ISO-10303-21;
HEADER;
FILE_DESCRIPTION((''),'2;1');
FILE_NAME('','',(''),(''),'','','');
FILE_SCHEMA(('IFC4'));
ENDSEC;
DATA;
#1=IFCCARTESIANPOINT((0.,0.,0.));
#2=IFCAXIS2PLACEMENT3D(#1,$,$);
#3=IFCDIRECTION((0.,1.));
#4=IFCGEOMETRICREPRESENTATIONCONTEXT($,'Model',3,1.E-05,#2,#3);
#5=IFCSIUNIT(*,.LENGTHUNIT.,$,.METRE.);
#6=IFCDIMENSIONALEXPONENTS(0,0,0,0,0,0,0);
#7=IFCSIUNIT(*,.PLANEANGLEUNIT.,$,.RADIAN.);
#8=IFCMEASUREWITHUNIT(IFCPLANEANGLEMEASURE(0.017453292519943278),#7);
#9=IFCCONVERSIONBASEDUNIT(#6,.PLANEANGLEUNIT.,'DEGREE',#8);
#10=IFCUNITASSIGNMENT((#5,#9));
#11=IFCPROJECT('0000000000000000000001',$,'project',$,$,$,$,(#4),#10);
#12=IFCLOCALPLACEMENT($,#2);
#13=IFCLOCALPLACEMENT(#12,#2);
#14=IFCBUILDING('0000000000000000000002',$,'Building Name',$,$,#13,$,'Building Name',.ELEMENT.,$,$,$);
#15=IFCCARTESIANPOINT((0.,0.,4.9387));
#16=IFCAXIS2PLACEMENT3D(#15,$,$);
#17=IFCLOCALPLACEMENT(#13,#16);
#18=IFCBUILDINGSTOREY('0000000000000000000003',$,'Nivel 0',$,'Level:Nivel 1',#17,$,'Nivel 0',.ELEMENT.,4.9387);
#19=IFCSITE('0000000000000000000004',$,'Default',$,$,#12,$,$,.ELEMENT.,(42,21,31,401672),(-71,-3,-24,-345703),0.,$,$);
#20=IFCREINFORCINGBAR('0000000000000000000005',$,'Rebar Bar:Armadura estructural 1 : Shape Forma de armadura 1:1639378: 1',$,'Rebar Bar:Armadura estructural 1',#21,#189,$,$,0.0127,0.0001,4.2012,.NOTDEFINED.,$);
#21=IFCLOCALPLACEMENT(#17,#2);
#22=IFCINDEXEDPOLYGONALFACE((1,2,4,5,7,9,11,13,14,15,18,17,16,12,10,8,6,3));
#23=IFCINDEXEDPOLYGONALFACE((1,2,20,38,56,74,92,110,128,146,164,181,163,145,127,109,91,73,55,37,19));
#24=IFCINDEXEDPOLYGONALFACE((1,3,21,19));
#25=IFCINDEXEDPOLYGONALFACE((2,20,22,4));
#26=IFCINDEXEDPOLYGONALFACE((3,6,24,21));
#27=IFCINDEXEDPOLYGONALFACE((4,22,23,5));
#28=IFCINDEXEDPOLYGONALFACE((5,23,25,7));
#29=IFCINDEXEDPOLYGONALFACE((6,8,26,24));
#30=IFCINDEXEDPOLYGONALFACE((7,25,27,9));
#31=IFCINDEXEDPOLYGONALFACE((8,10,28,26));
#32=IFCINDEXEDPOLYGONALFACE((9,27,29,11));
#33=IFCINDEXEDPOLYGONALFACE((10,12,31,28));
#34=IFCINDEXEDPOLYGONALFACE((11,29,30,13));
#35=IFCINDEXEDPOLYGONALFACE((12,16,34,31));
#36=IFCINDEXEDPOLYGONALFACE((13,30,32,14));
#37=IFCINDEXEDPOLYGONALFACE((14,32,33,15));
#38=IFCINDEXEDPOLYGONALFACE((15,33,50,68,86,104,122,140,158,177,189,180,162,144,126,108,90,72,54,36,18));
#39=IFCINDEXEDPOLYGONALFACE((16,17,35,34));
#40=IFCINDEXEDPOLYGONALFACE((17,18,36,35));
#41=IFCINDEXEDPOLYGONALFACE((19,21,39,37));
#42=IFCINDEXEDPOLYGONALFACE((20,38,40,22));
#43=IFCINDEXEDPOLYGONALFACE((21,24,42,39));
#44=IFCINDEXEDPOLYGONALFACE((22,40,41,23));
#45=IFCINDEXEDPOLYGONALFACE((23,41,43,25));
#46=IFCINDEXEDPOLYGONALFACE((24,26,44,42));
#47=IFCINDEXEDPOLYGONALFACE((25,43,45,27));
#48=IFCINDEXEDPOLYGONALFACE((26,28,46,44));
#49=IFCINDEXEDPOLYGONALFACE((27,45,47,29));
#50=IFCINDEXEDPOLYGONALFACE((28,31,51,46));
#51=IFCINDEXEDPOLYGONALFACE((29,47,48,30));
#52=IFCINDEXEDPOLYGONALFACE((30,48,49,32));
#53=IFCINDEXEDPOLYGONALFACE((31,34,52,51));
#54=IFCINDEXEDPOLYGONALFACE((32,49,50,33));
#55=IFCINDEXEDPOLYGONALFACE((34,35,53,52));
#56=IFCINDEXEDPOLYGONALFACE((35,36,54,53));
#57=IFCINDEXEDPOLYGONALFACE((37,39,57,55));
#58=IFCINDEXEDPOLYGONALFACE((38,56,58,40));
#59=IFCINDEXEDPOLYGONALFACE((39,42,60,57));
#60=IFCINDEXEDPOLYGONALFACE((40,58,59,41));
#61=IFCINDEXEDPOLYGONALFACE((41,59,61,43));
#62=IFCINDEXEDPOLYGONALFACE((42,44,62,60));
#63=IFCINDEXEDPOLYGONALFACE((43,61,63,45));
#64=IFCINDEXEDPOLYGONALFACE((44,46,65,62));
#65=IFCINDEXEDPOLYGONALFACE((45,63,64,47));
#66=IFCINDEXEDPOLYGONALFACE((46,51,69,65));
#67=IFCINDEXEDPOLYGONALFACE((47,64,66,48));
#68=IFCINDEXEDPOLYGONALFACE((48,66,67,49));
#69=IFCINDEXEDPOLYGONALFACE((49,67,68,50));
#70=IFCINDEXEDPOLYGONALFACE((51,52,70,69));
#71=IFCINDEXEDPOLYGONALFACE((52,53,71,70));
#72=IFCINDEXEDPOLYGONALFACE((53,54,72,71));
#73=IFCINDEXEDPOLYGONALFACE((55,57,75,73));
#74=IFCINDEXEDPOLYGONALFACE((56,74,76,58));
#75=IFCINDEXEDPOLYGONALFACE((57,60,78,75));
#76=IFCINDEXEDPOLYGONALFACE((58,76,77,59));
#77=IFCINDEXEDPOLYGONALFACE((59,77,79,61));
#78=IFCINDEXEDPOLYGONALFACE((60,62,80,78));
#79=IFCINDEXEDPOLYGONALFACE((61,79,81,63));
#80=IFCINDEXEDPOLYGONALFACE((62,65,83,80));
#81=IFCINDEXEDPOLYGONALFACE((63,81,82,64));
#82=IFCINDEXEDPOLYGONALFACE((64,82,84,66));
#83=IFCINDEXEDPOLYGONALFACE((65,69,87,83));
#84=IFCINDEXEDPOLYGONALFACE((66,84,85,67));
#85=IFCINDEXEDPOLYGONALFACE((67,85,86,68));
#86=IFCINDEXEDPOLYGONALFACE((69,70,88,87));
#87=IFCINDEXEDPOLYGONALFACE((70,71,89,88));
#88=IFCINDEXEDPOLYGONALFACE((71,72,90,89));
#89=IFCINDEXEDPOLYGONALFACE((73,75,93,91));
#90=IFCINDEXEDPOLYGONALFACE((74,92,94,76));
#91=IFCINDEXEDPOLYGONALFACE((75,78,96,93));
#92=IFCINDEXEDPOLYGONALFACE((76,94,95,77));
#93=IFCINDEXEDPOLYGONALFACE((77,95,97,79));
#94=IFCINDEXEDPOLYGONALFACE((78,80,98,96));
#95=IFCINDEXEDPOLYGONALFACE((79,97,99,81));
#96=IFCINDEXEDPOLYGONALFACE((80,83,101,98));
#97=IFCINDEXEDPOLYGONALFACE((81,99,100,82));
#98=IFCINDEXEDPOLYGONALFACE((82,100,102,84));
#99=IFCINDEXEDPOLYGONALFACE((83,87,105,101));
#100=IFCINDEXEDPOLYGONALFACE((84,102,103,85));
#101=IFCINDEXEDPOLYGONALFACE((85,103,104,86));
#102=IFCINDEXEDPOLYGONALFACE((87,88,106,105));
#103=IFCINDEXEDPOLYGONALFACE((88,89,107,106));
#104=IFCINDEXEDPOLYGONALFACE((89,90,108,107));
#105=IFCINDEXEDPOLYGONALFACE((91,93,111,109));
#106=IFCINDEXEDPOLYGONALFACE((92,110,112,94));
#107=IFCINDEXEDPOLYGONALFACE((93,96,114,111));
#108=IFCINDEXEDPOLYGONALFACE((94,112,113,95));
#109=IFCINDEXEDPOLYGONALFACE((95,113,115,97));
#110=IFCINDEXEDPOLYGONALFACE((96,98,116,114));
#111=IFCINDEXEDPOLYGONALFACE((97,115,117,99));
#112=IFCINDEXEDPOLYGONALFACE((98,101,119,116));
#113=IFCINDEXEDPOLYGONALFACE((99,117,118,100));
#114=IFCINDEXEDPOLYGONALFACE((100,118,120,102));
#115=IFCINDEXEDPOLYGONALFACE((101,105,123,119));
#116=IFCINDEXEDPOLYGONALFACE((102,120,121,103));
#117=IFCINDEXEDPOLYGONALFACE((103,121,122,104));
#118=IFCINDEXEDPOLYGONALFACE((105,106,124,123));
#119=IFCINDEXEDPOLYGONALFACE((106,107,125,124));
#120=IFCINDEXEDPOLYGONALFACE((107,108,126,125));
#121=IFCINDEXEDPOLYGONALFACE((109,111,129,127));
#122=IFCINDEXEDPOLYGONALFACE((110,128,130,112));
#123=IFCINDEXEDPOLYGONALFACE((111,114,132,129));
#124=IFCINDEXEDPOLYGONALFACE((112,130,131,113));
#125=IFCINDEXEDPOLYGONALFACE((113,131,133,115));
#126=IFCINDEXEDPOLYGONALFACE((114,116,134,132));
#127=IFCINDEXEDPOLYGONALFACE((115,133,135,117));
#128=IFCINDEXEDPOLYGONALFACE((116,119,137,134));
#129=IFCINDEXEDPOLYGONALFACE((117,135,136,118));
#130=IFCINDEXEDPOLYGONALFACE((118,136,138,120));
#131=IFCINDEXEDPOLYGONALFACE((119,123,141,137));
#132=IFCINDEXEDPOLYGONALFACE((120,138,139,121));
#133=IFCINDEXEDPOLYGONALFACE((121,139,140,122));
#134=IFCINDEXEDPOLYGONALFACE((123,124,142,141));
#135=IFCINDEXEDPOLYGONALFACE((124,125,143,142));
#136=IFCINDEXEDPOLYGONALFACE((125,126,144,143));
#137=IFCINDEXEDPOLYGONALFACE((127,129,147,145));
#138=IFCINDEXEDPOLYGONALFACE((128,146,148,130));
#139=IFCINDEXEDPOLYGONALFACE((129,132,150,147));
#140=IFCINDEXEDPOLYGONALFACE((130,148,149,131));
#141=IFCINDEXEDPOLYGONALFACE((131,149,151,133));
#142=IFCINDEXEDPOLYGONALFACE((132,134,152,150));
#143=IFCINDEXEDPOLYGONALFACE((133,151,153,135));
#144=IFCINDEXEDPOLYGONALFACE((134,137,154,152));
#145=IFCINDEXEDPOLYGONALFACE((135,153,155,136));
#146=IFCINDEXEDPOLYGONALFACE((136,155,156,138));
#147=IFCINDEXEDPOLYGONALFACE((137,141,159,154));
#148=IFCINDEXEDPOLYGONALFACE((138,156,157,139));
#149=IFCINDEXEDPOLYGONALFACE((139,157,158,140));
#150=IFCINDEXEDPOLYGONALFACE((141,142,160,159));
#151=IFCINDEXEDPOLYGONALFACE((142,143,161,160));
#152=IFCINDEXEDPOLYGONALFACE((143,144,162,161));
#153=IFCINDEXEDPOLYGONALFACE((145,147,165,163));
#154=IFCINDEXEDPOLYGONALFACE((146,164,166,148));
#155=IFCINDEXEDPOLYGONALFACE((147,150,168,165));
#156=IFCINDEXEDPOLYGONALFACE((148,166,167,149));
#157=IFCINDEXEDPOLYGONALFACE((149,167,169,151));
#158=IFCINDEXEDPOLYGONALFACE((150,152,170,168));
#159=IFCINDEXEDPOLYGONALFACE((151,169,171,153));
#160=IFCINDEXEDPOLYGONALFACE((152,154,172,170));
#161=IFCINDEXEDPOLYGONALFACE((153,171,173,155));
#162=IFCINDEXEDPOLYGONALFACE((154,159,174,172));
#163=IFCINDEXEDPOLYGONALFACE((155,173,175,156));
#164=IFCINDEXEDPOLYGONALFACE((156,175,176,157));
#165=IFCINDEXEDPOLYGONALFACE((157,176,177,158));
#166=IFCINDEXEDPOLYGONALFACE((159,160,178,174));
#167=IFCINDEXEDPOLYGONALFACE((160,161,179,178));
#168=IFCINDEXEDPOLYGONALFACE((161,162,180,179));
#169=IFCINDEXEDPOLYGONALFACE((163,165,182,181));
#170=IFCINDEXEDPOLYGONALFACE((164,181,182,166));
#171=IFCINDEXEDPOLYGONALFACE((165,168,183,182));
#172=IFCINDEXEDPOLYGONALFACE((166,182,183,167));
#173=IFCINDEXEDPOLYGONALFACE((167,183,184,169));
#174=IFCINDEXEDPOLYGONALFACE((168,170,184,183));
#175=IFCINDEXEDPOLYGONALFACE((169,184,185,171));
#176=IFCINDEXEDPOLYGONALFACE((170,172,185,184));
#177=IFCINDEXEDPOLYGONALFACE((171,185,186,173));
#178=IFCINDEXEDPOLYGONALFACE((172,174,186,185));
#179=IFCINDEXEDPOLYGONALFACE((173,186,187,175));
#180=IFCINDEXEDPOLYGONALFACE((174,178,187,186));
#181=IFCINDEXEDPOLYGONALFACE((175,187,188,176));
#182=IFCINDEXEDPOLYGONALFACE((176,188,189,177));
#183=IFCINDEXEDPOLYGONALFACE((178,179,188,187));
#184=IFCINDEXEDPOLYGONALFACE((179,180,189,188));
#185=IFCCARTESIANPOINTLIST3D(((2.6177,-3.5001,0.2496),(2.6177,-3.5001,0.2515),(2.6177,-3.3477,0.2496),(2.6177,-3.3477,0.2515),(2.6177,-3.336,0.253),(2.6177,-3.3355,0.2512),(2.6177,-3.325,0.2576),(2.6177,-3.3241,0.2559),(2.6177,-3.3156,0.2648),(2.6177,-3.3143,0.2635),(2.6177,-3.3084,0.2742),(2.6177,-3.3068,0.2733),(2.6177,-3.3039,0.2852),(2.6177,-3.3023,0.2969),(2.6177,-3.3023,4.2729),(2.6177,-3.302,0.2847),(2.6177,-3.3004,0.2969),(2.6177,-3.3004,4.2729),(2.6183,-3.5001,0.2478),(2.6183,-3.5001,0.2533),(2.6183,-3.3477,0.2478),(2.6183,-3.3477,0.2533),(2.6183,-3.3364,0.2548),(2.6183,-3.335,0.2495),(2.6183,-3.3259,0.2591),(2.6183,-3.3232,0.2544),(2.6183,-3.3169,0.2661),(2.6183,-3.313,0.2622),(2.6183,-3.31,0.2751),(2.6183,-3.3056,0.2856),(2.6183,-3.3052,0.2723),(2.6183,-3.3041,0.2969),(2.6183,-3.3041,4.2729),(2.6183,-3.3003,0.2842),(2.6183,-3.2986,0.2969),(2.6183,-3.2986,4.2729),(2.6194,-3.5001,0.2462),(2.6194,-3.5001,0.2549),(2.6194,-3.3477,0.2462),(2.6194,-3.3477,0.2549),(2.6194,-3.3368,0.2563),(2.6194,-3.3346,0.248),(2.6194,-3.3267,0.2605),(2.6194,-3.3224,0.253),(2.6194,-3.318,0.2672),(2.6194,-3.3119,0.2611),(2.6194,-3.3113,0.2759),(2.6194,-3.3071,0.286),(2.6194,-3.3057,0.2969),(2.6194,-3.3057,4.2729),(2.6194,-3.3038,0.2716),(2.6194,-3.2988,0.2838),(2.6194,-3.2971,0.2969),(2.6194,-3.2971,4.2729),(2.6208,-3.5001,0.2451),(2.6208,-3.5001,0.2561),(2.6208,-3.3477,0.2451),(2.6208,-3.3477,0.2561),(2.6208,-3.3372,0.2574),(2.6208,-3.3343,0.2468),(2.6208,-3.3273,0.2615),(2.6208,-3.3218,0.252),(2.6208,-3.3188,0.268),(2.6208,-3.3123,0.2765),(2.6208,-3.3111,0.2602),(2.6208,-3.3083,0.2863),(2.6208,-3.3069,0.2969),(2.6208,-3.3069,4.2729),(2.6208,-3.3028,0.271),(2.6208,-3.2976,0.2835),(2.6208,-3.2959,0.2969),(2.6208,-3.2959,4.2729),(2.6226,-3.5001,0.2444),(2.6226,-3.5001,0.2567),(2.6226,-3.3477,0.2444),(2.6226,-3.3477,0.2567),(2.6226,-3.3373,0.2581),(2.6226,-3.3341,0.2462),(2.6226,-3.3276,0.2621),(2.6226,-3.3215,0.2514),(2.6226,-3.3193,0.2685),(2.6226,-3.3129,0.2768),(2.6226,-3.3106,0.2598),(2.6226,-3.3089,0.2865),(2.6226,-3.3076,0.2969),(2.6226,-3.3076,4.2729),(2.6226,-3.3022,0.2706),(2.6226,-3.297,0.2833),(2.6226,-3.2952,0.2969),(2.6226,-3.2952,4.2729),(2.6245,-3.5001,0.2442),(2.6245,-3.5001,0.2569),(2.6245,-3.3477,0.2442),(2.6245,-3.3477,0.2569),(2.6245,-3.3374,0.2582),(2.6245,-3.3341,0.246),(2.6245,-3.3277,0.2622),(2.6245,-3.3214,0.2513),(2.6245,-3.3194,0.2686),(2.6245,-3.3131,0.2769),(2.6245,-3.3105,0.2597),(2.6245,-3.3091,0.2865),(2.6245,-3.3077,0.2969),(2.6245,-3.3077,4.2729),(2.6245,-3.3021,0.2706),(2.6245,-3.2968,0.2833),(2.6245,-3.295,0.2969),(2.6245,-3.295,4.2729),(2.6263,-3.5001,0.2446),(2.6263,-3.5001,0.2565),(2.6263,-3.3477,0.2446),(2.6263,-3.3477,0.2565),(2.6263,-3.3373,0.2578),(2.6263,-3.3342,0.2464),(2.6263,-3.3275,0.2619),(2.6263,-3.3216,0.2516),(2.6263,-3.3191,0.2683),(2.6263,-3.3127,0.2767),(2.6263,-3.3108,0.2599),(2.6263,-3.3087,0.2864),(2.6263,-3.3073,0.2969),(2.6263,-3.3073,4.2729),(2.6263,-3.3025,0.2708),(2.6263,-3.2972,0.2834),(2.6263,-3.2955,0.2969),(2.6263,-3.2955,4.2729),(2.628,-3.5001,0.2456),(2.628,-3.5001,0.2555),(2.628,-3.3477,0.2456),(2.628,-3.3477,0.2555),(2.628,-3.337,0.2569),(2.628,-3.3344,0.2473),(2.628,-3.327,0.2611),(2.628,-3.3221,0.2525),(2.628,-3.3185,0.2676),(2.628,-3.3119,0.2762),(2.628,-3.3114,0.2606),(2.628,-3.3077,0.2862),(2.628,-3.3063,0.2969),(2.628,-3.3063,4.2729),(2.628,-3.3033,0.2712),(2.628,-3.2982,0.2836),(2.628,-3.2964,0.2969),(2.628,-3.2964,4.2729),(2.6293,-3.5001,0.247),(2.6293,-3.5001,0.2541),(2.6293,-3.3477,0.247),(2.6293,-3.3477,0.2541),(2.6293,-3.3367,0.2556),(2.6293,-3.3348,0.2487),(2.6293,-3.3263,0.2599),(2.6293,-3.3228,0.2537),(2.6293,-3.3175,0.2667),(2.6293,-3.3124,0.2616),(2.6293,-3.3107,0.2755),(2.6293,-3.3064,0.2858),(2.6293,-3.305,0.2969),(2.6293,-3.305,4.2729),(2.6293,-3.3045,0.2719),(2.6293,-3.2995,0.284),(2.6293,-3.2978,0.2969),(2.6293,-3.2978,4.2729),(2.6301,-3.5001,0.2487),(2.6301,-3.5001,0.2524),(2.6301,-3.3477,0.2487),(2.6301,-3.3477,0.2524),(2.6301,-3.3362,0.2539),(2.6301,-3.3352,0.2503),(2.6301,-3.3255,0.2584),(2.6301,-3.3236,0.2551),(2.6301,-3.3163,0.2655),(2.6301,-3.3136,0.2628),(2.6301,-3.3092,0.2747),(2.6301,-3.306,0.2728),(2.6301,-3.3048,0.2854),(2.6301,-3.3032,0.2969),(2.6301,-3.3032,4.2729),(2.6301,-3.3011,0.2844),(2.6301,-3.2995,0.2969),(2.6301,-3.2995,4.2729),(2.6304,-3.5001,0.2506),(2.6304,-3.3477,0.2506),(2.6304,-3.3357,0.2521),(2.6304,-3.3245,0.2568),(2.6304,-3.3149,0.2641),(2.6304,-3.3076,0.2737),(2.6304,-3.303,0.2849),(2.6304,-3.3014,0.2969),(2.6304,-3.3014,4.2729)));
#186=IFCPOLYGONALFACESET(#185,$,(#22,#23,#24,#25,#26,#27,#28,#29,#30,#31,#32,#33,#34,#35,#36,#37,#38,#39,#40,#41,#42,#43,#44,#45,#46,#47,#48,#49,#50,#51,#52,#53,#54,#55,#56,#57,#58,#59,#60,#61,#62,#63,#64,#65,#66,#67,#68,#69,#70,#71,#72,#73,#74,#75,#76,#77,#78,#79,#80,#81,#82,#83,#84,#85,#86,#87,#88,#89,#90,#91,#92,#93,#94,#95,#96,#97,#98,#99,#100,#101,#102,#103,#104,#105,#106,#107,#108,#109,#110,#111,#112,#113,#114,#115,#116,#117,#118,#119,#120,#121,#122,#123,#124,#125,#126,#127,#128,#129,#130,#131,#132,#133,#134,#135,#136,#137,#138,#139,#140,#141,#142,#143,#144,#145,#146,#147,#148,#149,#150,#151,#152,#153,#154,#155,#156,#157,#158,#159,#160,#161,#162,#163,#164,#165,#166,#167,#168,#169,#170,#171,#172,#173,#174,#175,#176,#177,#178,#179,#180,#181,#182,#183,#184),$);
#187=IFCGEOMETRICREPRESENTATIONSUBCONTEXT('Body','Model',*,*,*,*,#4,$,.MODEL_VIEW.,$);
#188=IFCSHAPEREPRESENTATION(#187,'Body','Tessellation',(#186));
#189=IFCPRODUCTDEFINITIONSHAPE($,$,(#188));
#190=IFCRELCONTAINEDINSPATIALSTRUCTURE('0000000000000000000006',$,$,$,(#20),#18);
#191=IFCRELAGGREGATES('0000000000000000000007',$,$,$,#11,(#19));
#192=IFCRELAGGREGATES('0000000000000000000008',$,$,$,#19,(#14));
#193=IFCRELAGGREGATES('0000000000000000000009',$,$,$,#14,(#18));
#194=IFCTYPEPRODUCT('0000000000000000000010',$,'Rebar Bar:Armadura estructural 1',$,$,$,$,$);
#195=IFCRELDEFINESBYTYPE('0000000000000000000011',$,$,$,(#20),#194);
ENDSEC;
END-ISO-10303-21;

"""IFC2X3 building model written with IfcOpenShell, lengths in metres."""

from ifc_helpers import new_model, entity, si_unit, converted_unit, direction, frame, origin, place, context, subcontext, project, spatial, type_object, element, save


model = new_model("IFC2X3")

# Units and contexts
model_context = context("Model", 3, precision=1e-05, world=origin(), true_north=direction((0.0, 1.0)))
body_context = subcontext(model_context, "Body", "Model", "MODEL_VIEW")
ifc_project = project(units=[si_unit("LENGTHUNIT", "METRE"), converted_unit("PLANEANGLEUNIT", "DEGREE", entity("IfcPlaneAngleMeasure", 0.017453292519943278), si_unit("PLANEANGLEUNIT", "RADIAN"), dimensions=[0, 0, 0, 0, 0, 0, 0])], contexts=[model_context])

# Site, building, storey
site_placement = place(None, origin())
site = spatial("IfcSite", under=ifc_project, at=site_placement, Name="Default", CompositionType="ELEMENT", RefLatitude=(42, 21, 31, 401672), RefLongitude=(-71, -3, -24, -345703), RefElevation=0.0)
building_placement = place(site_placement, origin())
building = spatial("IfcBuilding", under=site, at=building_placement, Name="Building Name", LongName="Building Name", CompositionType="ELEMENT")
storey_placement = place(building_placement, frame((0.0, 0.0, 4.9387)))
storey = spatial("IfcBuildingStorey", under=building, at=storey_placement, Name="Nivel 0", ObjectType="Level:Nivel 1", LongName="Nivel 0", CompositionType="ELEMENT", Elevation=4.9387)

# Reinforcing bar
type_product = type_object("IfcTypeProduct", Name="Rebar Bar:Armadura estructural 1")
reinforcing_bar_1_placement = place(storey_placement, origin())
element("IfcReinforcingBar", 1, at=reinforcing_bar_1_placement, inside=storey, type_object=type_product, Name="Rebar Bar:Armadura estructural 1 : Shape Forma de armadura 1:1639378: 1", ObjectType="Rebar Bar:Armadura estructural 1", BarLength=4.2012, BarRole="NOTDEFINED", CrossSectionArea=0.0001, NominalDiameter=0.0127, context=body_context, shape_type="AdvancedSweptSolid", body=[
    entity("IfcSweptDiskSolid", entity("IfcCompositeCurve", [entity("IfcCompositeCurveSegment", "CONTINUOUS", True, entity("IfcPolyline", [entity("IfcCartesianPoint", [2.624, -3.5001, 0.2506]), entity("IfcCartesianPoint", [2.624, -3.3477, 0.2506])])), entity("IfcCompositeCurveSegment", "CONTINUOUS", True, entity("IfcTrimmedCurve", entity("IfcCircle", entity("IfcAxis2Placement3D", entity("IfcCartesianPoint", [2.624, -3.3477, 0.2969]), entity("IfcDirection", [1.0, 0.0, 0.0]), entity("IfcDirection", [0.0, 1.0, 0.0])), 0.0464), [entity("IfcParameterValue", 270.0)], [entity("IfcParameterValue", 360.0)], True, "PARAMETER")), entity("IfcCompositeCurveSegment", "CONTINUOUS", True, entity("IfcPolyline", [entity("IfcCartesianPoint", [2.624, -3.3014, 0.2969]), entity("IfcCartesianPoint", [2.624, -3.3014, 4.2729])]))], False), 0.0063, None, 0.0, 92.0),
])

save(model, "model.ifc")
